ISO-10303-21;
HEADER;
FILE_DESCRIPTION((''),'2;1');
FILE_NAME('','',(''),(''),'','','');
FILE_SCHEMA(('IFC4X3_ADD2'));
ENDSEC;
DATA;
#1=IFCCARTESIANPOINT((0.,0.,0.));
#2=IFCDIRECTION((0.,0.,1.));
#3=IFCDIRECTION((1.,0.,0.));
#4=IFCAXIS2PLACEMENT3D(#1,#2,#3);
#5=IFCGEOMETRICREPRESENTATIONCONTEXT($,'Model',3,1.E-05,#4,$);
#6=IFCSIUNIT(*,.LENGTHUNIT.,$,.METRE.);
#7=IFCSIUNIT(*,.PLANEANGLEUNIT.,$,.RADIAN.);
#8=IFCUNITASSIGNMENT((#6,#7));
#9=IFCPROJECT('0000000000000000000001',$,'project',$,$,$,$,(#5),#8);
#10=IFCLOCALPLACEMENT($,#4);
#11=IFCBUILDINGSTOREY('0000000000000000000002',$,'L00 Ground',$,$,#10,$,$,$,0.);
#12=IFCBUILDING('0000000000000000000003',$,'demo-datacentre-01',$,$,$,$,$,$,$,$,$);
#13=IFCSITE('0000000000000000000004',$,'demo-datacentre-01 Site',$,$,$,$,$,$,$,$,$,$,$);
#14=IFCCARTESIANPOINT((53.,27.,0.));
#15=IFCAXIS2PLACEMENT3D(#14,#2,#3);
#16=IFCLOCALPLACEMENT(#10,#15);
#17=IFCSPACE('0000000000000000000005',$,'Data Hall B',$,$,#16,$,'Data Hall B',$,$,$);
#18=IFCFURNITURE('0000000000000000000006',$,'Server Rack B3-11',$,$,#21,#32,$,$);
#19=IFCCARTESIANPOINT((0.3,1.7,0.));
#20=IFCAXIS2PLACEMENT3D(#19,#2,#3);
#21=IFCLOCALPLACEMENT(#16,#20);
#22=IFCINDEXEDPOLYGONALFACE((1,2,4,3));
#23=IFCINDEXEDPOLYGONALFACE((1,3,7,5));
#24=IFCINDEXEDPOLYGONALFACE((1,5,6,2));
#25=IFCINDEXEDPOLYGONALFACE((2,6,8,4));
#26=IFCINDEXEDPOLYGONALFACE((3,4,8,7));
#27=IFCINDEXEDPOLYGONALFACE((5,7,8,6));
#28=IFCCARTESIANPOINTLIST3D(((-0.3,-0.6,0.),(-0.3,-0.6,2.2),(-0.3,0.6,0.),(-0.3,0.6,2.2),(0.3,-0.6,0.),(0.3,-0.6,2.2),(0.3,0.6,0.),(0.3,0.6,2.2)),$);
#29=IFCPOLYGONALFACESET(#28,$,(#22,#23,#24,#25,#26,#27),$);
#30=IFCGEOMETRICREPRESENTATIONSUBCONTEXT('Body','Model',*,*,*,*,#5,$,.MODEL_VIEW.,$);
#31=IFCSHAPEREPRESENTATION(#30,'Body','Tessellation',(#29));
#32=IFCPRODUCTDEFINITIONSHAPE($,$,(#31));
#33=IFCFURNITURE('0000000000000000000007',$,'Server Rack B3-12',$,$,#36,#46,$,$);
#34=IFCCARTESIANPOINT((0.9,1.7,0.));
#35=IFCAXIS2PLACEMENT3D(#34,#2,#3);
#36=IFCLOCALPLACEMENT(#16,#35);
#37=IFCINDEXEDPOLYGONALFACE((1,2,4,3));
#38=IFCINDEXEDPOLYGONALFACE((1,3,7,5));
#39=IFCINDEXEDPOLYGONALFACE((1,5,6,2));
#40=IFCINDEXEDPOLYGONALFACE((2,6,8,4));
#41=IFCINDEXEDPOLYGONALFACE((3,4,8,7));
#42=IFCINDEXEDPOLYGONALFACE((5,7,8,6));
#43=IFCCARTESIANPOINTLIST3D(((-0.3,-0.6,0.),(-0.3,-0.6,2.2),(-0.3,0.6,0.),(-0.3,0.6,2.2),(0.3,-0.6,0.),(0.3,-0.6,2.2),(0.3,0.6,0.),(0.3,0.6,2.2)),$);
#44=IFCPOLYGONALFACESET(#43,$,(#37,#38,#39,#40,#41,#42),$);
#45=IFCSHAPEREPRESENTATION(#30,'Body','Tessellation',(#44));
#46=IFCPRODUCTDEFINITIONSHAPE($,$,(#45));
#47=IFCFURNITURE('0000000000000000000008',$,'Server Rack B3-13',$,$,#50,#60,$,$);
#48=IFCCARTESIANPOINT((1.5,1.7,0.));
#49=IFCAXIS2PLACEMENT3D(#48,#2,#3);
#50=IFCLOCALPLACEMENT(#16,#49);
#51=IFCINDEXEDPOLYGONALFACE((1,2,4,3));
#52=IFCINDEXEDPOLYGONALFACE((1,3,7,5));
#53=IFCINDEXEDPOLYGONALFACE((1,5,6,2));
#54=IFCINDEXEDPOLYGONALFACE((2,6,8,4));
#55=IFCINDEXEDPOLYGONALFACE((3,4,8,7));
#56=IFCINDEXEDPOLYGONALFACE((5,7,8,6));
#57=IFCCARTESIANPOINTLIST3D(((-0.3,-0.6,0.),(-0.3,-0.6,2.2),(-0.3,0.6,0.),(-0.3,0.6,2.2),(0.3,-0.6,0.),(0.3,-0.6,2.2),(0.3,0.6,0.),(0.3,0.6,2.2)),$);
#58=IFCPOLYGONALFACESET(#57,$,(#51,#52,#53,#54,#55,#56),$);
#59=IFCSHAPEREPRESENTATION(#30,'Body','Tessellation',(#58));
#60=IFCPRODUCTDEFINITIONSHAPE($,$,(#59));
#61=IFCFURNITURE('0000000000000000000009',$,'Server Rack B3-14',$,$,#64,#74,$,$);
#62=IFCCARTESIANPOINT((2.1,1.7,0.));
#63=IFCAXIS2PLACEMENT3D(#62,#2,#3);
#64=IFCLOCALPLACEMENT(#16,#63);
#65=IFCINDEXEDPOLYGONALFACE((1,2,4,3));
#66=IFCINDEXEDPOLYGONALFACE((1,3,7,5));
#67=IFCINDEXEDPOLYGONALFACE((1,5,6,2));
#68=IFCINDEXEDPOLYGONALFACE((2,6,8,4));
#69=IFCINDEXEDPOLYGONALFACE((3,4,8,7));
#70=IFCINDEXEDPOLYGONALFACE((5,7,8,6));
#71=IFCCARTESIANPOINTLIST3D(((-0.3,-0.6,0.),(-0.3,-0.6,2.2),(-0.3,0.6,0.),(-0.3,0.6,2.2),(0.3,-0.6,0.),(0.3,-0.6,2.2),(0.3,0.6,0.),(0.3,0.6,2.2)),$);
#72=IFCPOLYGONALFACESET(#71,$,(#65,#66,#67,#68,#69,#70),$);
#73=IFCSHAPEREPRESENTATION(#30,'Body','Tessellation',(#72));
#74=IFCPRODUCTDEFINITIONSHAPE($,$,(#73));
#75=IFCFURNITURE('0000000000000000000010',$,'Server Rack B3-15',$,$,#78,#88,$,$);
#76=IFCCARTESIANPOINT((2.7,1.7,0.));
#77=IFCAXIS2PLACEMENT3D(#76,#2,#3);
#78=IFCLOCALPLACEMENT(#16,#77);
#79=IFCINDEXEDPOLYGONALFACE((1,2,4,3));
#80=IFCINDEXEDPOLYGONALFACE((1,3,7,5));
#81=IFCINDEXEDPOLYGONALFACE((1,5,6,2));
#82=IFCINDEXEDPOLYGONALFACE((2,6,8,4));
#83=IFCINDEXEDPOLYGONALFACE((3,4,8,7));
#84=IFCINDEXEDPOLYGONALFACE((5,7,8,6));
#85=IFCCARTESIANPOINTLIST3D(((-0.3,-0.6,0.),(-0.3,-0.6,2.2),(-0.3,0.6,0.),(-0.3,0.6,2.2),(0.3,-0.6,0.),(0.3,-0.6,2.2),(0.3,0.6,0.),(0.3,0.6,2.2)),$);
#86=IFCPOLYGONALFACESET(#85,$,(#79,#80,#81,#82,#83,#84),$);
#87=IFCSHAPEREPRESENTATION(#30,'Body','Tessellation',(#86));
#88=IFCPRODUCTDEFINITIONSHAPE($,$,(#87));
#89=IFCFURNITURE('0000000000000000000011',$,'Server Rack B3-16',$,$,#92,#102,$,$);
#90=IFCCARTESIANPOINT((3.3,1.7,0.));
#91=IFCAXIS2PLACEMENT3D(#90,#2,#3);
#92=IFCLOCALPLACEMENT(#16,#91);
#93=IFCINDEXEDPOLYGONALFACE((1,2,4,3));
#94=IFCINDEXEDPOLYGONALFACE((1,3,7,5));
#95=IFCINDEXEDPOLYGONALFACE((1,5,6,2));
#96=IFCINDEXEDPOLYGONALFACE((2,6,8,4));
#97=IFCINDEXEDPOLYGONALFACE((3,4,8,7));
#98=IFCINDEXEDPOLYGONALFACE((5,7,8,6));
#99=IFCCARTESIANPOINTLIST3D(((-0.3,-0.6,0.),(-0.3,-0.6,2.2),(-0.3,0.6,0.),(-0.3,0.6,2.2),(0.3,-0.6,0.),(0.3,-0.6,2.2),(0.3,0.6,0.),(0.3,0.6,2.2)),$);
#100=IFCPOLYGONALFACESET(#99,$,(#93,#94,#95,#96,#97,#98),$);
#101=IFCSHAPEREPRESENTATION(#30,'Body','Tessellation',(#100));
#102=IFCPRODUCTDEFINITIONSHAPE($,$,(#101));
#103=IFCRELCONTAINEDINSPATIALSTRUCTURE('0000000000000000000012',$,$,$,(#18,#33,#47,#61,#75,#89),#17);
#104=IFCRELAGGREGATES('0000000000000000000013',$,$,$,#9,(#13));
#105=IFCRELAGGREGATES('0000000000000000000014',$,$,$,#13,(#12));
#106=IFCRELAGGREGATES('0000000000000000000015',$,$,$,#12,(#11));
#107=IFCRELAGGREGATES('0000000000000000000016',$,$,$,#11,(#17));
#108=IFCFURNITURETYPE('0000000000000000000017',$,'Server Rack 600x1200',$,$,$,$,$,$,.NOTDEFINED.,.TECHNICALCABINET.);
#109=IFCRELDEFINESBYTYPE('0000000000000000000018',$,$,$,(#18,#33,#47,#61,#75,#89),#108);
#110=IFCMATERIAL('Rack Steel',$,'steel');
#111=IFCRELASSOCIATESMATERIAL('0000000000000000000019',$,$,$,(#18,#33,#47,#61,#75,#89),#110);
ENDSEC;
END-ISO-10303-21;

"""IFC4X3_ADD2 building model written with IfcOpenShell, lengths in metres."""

from ifc_helpers import new_model, si_unit, frame, origin_with_axes, place, context, subcontext, project, spatial, rectangle, extrude, material, type_object, element, save


model = new_model("IFC4X3_ADD2")

# Units and contexts
model_context = context("Model", 3, precision=1e-05, world=origin_with_axes())
body_context = subcontext(model_context, "Body", "Model", "MODEL_VIEW")
ifc_project = project(units=[si_unit("LENGTHUNIT", "METRE"), si_unit("PLANEANGLEUNIT", "RADIAN")], contexts=[model_context])

# Site, building, storey
site = spatial("IfcSite", under=ifc_project, Name="demo-datacentre-01 Site")
building = spatial("IfcBuilding", under=site, Name="demo-datacentre-01")
storey_placement = place(None, origin_with_axes())
storey = spatial("IfcBuildingStorey", under=building, at=storey_placement, Name="L00 Ground", Elevation=0.0)

# Shared definitions
space_placement = place(storey_placement, frame((53.0, 27.0, 0.0), z_axis=(0.0, 0.0, 1.0), x_axis=(1.0, 0.0, 0.0)))
space = spatial("IfcSpace", under=storey, at=space_placement, Name="Data Hall B", LongName="Data Hall B")

# Furniture
ifc_material_1 = material(Name="Rack Steel", Category="steel")
furniture_type = type_object("IfcFurnitureType", Name="Server Rack 600x1200", AssemblyPlace="NOTDEFINED", PredefinedType="TECHNICALCABINET")
for number, where, z_axis, x_axis, name in (
    (1, (0.3, 1.7, 0.0), (0.0, 0.0, 1.0), (1.0, 0.0, 0.0), "Server Rack B3-11"),
    (2, (0.9, 1.7, 0.0), (0.0, 0.0, 1.0), (1.0, 0.0, 0.0), "Server Rack B3-12"),
    (3, (1.5, 1.7, 0.0), (0.0, 0.0, 1.0), (1.0, 0.0, 0.0), "Server Rack B3-13"),
    (4, (2.1, 1.7, 0.0), (0.0, 0.0, 1.0), (1.0, 0.0, 0.0), "Server Rack B3-14"),
    (5, (2.7, 1.7, 0.0), (0.0, 0.0, 1.0), (1.0, 0.0, 0.0), "Server Rack B3-15"),
    (6, (3.3, 1.7, 0.0), (0.0, 0.0, 1.0), (1.0, 0.0, 0.0), "Server Rack B3-16"),
):
    element("IfcFurniture", number, at=place(space_placement, frame(where, z_axis=z_axis, x_axis=x_axis)), inside=space, type_object=furniture_type, material=ifc_material_1, Name=name, context=body_context, shape_type="SweptSolid", body=[
        extrude(rectangle(XDim=0.6, YDim=1.2), origin_with_axes(), (0.0, 0.0, 1.0), 2.2),
    ])

save(model, "model.ifc")
